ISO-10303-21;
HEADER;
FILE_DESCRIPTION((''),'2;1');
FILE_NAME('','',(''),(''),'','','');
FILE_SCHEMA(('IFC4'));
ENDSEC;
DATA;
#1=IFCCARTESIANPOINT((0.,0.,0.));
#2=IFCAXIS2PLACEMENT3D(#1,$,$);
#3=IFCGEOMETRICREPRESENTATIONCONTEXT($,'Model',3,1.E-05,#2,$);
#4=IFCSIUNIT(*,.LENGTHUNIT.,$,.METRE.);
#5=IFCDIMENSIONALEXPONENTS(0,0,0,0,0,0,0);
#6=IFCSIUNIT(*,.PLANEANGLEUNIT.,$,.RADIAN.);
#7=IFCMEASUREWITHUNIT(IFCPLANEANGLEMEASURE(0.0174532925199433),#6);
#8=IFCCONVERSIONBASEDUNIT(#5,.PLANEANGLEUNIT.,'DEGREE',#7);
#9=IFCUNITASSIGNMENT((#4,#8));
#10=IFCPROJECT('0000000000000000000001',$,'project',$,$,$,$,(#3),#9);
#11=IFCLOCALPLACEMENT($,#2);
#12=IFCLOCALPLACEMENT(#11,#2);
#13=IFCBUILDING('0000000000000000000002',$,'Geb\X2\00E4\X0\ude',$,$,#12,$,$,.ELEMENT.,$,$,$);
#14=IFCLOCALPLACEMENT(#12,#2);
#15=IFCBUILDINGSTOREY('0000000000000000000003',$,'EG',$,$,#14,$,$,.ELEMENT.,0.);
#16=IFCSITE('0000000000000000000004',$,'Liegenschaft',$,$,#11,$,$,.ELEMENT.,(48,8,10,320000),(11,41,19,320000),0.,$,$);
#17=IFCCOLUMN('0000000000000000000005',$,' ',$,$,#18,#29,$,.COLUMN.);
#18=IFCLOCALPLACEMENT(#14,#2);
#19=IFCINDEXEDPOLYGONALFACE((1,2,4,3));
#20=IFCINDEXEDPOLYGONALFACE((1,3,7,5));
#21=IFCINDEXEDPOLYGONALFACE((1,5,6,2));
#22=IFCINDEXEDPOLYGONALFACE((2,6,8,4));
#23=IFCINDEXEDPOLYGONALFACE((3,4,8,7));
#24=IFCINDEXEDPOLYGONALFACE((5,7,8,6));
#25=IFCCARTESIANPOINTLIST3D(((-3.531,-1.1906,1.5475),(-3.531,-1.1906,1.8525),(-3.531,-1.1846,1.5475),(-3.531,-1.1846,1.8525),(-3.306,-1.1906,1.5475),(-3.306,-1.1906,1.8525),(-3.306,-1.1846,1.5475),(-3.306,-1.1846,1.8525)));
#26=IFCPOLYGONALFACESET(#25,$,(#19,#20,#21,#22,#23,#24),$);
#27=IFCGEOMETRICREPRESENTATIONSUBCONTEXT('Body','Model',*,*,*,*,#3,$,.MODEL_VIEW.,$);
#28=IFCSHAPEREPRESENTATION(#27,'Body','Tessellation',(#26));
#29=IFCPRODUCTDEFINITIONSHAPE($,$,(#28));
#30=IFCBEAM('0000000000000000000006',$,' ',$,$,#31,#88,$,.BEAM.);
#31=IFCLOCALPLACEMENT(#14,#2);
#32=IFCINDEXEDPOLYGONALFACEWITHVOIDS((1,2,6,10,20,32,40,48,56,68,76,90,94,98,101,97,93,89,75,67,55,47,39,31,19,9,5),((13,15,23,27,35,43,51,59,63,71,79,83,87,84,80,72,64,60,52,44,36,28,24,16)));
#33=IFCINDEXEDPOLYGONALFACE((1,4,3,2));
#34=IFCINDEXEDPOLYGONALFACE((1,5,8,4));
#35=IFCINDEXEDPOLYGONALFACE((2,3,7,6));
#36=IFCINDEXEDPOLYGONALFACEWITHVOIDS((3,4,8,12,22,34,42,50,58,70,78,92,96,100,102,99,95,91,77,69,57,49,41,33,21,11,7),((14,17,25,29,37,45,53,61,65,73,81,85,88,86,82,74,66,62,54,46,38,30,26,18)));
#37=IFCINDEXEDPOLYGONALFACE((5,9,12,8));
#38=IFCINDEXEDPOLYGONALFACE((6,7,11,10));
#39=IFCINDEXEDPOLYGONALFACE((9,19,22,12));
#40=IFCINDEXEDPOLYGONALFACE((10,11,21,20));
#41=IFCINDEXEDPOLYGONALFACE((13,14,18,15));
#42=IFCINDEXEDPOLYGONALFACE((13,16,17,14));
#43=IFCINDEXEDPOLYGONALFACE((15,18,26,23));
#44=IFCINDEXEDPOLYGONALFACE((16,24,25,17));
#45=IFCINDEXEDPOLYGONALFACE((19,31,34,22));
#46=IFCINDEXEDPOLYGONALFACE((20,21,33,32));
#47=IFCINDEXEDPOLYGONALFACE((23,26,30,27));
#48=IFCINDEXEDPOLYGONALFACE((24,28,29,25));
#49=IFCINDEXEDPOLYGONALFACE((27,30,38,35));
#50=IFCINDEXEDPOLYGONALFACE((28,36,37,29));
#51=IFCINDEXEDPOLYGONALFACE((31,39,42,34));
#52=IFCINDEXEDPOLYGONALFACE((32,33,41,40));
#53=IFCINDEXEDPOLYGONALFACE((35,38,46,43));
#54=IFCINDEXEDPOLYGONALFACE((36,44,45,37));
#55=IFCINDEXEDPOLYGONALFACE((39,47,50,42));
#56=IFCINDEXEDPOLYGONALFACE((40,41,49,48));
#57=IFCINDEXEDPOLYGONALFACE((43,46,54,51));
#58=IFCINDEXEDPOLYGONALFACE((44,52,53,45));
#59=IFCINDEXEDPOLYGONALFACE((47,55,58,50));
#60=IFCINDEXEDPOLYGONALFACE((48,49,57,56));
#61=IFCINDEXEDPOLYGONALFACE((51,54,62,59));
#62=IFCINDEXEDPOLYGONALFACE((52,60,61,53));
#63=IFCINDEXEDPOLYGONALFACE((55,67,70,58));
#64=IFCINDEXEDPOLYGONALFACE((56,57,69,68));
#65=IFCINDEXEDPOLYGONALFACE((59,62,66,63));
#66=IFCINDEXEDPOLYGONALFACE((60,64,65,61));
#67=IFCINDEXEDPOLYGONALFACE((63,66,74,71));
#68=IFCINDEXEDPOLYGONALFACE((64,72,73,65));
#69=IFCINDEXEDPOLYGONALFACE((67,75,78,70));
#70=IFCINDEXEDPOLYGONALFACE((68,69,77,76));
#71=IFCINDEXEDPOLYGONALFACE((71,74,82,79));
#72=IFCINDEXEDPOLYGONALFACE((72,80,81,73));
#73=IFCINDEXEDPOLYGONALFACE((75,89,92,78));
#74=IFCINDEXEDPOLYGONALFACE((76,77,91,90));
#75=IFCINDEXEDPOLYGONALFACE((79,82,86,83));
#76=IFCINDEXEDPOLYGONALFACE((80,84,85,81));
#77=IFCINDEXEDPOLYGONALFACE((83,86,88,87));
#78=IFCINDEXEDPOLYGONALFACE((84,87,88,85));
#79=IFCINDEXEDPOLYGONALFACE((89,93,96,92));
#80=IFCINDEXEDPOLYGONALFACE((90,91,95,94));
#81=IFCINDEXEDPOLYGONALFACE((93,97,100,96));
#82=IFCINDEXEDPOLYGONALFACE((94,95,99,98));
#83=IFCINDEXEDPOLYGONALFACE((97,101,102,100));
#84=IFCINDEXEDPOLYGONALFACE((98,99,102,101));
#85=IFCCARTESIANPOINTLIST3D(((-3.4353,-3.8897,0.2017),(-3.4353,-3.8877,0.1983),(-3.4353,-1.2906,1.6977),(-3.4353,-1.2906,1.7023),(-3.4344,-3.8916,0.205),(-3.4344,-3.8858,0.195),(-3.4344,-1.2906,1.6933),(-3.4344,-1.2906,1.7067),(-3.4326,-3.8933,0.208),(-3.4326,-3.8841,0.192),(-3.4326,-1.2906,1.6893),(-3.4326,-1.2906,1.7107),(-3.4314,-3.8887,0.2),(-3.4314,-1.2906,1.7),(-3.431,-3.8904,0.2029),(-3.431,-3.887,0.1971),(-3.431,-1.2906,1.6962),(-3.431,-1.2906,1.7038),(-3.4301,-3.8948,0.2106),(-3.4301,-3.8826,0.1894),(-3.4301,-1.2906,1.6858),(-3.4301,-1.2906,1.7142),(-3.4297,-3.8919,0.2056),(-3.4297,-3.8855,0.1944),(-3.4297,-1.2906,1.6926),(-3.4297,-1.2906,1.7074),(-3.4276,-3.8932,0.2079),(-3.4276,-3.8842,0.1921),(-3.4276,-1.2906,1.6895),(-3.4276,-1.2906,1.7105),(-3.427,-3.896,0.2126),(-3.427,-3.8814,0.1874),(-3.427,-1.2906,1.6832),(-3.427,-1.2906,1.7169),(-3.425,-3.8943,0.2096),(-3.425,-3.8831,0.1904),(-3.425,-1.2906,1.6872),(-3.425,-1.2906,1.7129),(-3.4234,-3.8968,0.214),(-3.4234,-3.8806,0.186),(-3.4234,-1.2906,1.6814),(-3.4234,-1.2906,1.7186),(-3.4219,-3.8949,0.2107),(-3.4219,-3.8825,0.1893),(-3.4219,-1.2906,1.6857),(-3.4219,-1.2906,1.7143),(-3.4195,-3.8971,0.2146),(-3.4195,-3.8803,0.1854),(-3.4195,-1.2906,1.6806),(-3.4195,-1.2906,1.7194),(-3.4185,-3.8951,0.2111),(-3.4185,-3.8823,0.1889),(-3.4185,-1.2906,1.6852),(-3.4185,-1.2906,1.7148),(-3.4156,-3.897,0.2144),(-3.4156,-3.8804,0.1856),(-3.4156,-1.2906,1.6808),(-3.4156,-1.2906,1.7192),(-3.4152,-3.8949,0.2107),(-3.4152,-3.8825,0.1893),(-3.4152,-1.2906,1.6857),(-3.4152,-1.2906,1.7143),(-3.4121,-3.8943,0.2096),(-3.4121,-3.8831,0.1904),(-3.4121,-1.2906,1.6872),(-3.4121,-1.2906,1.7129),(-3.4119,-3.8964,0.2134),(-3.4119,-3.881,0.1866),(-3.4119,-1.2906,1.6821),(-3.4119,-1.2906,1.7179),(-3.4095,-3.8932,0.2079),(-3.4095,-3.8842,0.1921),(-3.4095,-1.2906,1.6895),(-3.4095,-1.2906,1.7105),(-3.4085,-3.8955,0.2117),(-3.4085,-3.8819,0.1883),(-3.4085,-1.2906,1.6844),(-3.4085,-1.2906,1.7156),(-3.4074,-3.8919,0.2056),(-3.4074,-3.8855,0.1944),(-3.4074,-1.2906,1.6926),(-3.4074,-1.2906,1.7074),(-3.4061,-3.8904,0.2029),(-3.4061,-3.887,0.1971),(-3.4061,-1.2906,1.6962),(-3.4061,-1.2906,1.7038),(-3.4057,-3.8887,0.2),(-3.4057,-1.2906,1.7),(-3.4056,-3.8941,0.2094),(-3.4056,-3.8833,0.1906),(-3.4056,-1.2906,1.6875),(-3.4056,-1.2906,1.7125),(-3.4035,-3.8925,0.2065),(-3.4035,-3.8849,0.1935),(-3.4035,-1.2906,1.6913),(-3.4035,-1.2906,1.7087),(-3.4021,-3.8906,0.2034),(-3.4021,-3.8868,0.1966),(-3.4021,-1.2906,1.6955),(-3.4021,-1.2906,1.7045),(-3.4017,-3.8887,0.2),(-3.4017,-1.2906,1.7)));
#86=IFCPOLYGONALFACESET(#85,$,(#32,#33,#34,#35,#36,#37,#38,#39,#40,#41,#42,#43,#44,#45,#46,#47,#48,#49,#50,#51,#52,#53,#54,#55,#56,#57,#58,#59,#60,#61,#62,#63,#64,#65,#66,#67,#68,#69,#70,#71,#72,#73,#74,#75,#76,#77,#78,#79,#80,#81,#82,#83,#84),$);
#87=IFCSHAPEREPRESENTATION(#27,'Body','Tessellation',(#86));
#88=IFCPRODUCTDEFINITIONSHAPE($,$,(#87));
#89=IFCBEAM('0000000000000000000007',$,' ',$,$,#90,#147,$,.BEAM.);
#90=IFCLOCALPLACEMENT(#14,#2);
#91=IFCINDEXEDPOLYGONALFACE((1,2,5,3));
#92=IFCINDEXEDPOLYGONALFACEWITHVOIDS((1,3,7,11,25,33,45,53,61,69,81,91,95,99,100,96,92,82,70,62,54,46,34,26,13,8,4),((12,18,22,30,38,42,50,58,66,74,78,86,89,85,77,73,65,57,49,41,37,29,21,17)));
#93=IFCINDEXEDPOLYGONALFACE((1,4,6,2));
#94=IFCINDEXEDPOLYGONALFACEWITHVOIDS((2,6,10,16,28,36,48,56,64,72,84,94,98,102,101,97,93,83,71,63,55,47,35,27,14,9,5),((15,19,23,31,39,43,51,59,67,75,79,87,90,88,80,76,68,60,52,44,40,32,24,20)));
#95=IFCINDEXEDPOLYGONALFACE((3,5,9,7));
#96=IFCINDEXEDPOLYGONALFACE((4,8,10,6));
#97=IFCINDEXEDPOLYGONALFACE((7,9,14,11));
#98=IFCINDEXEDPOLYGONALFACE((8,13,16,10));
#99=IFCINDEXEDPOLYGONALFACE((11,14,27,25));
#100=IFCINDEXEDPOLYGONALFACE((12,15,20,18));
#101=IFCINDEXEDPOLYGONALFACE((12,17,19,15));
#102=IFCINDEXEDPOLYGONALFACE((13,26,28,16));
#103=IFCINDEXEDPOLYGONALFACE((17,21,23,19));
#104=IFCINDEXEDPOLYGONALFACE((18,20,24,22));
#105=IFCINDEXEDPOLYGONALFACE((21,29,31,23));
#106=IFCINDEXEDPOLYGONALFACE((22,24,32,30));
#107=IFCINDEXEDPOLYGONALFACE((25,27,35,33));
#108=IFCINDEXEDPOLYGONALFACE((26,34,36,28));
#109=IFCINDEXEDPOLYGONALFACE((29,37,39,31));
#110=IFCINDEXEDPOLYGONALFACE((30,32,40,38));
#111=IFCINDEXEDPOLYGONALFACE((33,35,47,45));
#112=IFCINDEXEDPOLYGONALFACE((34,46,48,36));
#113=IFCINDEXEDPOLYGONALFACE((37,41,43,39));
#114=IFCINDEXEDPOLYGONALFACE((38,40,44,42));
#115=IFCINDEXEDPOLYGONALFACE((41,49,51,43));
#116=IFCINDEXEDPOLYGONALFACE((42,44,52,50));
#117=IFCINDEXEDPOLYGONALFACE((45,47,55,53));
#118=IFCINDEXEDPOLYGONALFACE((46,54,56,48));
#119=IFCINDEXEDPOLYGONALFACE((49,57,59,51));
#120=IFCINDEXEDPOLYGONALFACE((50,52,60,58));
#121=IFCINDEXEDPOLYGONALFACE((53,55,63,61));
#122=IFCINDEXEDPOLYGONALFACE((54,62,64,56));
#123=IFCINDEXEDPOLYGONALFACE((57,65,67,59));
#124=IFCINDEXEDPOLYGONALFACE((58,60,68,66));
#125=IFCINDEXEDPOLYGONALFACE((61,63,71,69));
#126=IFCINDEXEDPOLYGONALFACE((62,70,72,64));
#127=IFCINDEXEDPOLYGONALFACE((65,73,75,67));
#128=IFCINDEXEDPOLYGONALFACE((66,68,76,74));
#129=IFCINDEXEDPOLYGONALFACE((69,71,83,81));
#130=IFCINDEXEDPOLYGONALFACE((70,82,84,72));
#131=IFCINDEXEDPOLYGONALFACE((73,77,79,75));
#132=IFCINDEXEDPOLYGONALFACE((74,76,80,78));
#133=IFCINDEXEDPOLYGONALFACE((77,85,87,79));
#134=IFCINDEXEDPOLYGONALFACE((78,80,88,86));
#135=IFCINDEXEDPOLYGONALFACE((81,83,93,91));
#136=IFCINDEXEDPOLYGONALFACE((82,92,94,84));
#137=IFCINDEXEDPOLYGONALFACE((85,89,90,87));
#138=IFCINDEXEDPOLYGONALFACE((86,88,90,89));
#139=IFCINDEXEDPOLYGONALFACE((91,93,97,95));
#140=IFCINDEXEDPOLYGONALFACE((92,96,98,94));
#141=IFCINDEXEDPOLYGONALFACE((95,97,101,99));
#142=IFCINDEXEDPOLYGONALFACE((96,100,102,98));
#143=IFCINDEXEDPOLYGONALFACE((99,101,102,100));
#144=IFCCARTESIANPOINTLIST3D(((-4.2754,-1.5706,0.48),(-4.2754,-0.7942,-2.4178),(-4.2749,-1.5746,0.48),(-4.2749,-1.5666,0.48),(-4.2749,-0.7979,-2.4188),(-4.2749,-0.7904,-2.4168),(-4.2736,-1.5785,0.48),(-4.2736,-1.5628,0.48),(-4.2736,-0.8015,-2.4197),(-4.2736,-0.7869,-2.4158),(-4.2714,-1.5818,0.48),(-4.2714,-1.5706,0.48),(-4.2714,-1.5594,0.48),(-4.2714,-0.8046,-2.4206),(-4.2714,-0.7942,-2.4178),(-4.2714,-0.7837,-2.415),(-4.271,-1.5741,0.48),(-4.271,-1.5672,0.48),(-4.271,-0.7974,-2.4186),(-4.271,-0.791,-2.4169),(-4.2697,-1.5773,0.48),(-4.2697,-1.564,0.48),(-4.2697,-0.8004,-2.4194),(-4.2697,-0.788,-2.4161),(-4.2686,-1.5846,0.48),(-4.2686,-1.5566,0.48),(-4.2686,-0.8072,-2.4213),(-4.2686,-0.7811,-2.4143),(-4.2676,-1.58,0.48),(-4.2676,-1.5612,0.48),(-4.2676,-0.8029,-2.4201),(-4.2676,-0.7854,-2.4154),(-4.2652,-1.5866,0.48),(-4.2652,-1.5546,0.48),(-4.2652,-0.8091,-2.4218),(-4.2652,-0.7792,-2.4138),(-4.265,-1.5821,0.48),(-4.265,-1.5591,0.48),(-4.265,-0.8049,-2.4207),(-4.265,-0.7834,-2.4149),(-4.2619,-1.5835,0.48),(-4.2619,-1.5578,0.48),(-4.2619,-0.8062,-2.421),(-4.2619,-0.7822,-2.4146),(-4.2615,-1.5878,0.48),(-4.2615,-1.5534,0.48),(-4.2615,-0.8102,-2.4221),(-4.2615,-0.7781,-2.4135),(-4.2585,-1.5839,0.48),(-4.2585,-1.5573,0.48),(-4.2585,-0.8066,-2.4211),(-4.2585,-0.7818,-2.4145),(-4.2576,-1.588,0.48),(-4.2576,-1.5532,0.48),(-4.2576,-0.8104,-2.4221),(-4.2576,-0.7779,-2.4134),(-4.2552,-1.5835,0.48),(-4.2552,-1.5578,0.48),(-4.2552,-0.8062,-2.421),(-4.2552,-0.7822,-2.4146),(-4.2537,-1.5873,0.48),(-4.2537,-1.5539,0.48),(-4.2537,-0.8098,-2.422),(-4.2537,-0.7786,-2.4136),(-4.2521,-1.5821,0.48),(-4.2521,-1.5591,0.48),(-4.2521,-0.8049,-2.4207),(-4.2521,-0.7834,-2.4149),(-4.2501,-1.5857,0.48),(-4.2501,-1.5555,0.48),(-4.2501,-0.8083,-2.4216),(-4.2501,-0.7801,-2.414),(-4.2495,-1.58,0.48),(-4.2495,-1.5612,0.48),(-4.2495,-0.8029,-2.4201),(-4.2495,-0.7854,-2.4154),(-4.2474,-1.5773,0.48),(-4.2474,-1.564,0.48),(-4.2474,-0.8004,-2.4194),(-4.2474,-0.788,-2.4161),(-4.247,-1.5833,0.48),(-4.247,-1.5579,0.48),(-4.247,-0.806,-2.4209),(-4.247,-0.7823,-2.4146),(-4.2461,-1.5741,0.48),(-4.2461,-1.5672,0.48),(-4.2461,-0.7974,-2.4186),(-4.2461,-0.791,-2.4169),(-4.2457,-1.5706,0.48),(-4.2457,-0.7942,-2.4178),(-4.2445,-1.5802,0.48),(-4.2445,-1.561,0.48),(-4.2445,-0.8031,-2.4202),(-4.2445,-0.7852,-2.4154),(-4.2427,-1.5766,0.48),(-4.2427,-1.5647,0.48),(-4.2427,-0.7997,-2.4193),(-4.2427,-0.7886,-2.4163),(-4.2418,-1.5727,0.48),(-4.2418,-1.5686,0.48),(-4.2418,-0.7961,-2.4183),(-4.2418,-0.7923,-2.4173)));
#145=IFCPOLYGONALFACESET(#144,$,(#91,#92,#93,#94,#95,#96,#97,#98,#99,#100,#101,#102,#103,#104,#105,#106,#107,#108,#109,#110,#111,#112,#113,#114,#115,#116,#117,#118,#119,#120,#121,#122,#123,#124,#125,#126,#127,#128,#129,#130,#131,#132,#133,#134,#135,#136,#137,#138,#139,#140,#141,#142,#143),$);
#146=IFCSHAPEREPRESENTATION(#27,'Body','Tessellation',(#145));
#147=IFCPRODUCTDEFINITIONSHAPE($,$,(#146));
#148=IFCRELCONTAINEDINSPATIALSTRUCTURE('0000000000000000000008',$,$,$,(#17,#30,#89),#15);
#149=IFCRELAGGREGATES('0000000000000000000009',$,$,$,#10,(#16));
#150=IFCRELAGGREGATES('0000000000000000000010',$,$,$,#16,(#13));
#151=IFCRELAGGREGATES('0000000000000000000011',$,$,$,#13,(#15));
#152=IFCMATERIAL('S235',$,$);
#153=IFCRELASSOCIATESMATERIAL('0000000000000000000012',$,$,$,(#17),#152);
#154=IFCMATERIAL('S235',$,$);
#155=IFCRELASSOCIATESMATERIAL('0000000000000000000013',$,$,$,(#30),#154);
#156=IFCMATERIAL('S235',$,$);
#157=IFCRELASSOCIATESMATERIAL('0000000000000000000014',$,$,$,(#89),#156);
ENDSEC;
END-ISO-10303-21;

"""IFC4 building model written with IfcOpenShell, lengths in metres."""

from ifc_helpers import new_model, entity, si_unit, converted_unit, frame, origin, origin_2d_with_axis, place, context, subcontext, project, spatial, polyline, rectangle, outline, extrude, clip, halfspace, material, element, save


model = new_model("IFC4")

# Units and contexts
model_context = context("Model", 3, precision=1e-05, world=origin())
body_context = subcontext(model_context, "Body", "Model", "MODEL_VIEW")
ifc_project = project(units=[si_unit("LENGTHUNIT", "METRE"), converted_unit("PLANEANGLEUNIT", "DEGREE", entity("IfcPlaneAngleMeasure", 0.0174532925199433), si_unit("PLANEANGLEUNIT", "RADIAN"), dimensions=[0, 0, 0, 0, 0, 0, 0])], contexts=[model_context])

# Site, building, storey
site_placement = place(None, origin())
site = spatial("IfcSite", under=ifc_project, at=site_placement, Name="Liegenschaft", CompositionType="ELEMENT", RefLatitude=(48, 8, 10, 320000), RefLongitude=(11, 41, 19, 320000), RefElevation=0.0)
building_placement = place(site_placement, origin())
building = spatial("IfcBuilding", under=site, at=building_placement, Name="Gebäude", CompositionType="ELEMENT")
storey_placement = place(building_placement, origin())
storey = spatial("IfcBuildingStorey", under=building, at=storey_placement, Name="EG", CompositionType="ELEMENT", Elevation=0.0)

# Column
ifc_material_1 = material(Name="S235")
column_placement = place(storey_placement, frame((-3.531, -1.1906, 1.5475)))
element("IfcColumn", 1, at=column_placement, inside=storey, material=ifc_material_1, Name=" ", PredefinedType="COLUMN", context=body_context, shape_type="SweptSolid", body=[
    extrude(rectangle(XDim=0.225, YDim=0.006, at=origin_2d_with_axis()), frame((0.1125, 0.003, 0.0), z_axis=(0.0, 0.0, 1.0), x_axis=(1.0, 0.0, 0.0)), (0.0, 0.0, 1.0), 0.305),
])

# Beams
ifc_material_2 = material(Name="S235")
beam_1_placement = place(storey_placement, frame((-3.4185, -1.2822, 1.7049), z_axis=(0.0, 0.0, 1.0), x_axis=(-1.0, 0.0, 0.0)))
element("IfcBeam", 2, at=beam_1_placement, inside=storey, material=ifc_material_2, Name=" ", PredefinedType="BEAM", context=body_context, shape_type="Clipping", body=[
    clip(extrude(outline(polyline([(0.0168, 0.0), (0.0164, 0.0039), (0.0151, 0.0076), (0.0129, 0.0108), (0.0101, 0.0135), (0.0067, 0.0155), (0.0029, 0.0166), (-0.001, 0.0168), (-0.0048, 0.0161), (-0.0084, 0.0146), (-0.0116, 0.0123), (-0.0141, 0.0093), (-0.0158, 0.0058), (-0.0167, 0.002), (-0.0167, -0.002), (-0.0158, -0.0058), (-0.0141, -0.0093), (-0.0116, -0.0123), (-0.0084, -0.0146), (-0.0048, -0.0161), (-0.001, -0.0168), (0.0029, -0.0166), (0.0067, -0.0155), (0.0101, -0.0135), (0.0129, -0.0108), (0.0151, -0.0076), (0.0164, -0.0039), (0.0168, 0.0)]), holes=[polyline([(-0.0129, 0.0), (-0.0124, 0.0033), (-0.0111, 0.0064), (-0.0091, 0.0091), (-0.0064, 0.0111), (-0.0033, 0.0124), (0.0, 0.0129), (0.0033, 0.0124), (0.0064, 0.0111), (0.0091, 0.0091), (0.0111, 0.0064), (0.0124, 0.0033), (0.0128, 0.0), (0.0124, -0.0033), (0.0111, -0.0064), (0.0091, -0.0091), (0.0064, -0.0111), (0.0033, -0.0124), (0.0, -0.0128), (-0.0033, -0.0124), (-0.0064, -0.0111), (-0.0091, -0.0091), (-0.0111, -0.0064), (-0.0124, -0.0033), (-0.0129, 0.0)])]), frame((0.0, 0.0, 0.0), z_axis=(0.0, 0.866025, -0.5), x_axis=(-1.0, 0.0, 0.0)), (0.0, 0.0, 1.0), 3.0097), halfspace(frame((0.0, 0.0084, -0.0049), z_axis=(0.0, 1.0, 0.0), x_axis=(1.0, 0.0, 0.0)), True)),
])
ifc_material_3 = material(Name="S235")
beam_2_placement = place(storey_placement, frame((-4.2585, -1.5718, 0.4844)))
element("IfcBeam", 3, at=beam_2_placement, inside=storey, material=ifc_material_3, Name=" ", PredefinedType="BEAM", context=body_context, shape_type="Clipping", body=[
    clip(extrude(outline(polyline([(0.0168, 0.0), (0.0164, 0.0039), (0.0151, 0.0076), (0.0129, 0.0108), (0.0101, 0.0135), (0.0067, 0.0155), (0.0029, 0.0166), (-0.001, 0.0168), (-0.0048, 0.0161), (-0.0084, 0.0146), (-0.0116, 0.0123), (-0.0141, 0.0093), (-0.0158, 0.0058), (-0.0167, 0.002), (-0.0167, -0.002), (-0.0158, -0.0058), (-0.0141, -0.0093), (-0.0116, -0.0123), (-0.0084, -0.0146), (-0.0048, -0.0161), (-0.001, -0.0168), (0.0029, -0.0166), (0.0067, -0.0155), (0.0101, -0.0135), (0.0129, -0.0108), (0.0151, -0.0076), (0.0164, -0.0039), (0.0168, 0.0)]), holes=[polyline([(-0.0129, 0.0), (-0.0124, 0.0033), (-0.0111, 0.0064), (-0.0091, 0.0091), (-0.0064, 0.0111), (-0.0033, 0.0124), (0.0, 0.0129), (0.0033, 0.0124), (0.0064, 0.0111), (0.0091, 0.0091), (0.0111, 0.0064), (0.0124, 0.0033), (0.0128, 0.0), (0.0124, -0.0033), (0.0111, -0.0064), (0.0091, -0.0091), (0.0064, -0.0111), (0.0033, -0.0124), (0.0, -0.0128), (-0.0033, -0.0124), (-0.0064, -0.0111), (-0.0091, -0.0091), (-0.0111, -0.0064), (-0.0124, -0.0033), (-0.0129, 0.0)])]), frame((0.0, 0.0, 0.0), z_axis=(0.0, 0.258819, -0.965926), x_axis=(-1.0, 0.0, 0.0)), (0.0, 0.0, 1.0), 3.0045), halfspace(frame((0.0, 0.0012, -0.0044), z_axis=(0.0, 0.0, -1.0), x_axis=(1.0, 0.0, 0.0)), True)),
])

save(model, "model.ifc")
